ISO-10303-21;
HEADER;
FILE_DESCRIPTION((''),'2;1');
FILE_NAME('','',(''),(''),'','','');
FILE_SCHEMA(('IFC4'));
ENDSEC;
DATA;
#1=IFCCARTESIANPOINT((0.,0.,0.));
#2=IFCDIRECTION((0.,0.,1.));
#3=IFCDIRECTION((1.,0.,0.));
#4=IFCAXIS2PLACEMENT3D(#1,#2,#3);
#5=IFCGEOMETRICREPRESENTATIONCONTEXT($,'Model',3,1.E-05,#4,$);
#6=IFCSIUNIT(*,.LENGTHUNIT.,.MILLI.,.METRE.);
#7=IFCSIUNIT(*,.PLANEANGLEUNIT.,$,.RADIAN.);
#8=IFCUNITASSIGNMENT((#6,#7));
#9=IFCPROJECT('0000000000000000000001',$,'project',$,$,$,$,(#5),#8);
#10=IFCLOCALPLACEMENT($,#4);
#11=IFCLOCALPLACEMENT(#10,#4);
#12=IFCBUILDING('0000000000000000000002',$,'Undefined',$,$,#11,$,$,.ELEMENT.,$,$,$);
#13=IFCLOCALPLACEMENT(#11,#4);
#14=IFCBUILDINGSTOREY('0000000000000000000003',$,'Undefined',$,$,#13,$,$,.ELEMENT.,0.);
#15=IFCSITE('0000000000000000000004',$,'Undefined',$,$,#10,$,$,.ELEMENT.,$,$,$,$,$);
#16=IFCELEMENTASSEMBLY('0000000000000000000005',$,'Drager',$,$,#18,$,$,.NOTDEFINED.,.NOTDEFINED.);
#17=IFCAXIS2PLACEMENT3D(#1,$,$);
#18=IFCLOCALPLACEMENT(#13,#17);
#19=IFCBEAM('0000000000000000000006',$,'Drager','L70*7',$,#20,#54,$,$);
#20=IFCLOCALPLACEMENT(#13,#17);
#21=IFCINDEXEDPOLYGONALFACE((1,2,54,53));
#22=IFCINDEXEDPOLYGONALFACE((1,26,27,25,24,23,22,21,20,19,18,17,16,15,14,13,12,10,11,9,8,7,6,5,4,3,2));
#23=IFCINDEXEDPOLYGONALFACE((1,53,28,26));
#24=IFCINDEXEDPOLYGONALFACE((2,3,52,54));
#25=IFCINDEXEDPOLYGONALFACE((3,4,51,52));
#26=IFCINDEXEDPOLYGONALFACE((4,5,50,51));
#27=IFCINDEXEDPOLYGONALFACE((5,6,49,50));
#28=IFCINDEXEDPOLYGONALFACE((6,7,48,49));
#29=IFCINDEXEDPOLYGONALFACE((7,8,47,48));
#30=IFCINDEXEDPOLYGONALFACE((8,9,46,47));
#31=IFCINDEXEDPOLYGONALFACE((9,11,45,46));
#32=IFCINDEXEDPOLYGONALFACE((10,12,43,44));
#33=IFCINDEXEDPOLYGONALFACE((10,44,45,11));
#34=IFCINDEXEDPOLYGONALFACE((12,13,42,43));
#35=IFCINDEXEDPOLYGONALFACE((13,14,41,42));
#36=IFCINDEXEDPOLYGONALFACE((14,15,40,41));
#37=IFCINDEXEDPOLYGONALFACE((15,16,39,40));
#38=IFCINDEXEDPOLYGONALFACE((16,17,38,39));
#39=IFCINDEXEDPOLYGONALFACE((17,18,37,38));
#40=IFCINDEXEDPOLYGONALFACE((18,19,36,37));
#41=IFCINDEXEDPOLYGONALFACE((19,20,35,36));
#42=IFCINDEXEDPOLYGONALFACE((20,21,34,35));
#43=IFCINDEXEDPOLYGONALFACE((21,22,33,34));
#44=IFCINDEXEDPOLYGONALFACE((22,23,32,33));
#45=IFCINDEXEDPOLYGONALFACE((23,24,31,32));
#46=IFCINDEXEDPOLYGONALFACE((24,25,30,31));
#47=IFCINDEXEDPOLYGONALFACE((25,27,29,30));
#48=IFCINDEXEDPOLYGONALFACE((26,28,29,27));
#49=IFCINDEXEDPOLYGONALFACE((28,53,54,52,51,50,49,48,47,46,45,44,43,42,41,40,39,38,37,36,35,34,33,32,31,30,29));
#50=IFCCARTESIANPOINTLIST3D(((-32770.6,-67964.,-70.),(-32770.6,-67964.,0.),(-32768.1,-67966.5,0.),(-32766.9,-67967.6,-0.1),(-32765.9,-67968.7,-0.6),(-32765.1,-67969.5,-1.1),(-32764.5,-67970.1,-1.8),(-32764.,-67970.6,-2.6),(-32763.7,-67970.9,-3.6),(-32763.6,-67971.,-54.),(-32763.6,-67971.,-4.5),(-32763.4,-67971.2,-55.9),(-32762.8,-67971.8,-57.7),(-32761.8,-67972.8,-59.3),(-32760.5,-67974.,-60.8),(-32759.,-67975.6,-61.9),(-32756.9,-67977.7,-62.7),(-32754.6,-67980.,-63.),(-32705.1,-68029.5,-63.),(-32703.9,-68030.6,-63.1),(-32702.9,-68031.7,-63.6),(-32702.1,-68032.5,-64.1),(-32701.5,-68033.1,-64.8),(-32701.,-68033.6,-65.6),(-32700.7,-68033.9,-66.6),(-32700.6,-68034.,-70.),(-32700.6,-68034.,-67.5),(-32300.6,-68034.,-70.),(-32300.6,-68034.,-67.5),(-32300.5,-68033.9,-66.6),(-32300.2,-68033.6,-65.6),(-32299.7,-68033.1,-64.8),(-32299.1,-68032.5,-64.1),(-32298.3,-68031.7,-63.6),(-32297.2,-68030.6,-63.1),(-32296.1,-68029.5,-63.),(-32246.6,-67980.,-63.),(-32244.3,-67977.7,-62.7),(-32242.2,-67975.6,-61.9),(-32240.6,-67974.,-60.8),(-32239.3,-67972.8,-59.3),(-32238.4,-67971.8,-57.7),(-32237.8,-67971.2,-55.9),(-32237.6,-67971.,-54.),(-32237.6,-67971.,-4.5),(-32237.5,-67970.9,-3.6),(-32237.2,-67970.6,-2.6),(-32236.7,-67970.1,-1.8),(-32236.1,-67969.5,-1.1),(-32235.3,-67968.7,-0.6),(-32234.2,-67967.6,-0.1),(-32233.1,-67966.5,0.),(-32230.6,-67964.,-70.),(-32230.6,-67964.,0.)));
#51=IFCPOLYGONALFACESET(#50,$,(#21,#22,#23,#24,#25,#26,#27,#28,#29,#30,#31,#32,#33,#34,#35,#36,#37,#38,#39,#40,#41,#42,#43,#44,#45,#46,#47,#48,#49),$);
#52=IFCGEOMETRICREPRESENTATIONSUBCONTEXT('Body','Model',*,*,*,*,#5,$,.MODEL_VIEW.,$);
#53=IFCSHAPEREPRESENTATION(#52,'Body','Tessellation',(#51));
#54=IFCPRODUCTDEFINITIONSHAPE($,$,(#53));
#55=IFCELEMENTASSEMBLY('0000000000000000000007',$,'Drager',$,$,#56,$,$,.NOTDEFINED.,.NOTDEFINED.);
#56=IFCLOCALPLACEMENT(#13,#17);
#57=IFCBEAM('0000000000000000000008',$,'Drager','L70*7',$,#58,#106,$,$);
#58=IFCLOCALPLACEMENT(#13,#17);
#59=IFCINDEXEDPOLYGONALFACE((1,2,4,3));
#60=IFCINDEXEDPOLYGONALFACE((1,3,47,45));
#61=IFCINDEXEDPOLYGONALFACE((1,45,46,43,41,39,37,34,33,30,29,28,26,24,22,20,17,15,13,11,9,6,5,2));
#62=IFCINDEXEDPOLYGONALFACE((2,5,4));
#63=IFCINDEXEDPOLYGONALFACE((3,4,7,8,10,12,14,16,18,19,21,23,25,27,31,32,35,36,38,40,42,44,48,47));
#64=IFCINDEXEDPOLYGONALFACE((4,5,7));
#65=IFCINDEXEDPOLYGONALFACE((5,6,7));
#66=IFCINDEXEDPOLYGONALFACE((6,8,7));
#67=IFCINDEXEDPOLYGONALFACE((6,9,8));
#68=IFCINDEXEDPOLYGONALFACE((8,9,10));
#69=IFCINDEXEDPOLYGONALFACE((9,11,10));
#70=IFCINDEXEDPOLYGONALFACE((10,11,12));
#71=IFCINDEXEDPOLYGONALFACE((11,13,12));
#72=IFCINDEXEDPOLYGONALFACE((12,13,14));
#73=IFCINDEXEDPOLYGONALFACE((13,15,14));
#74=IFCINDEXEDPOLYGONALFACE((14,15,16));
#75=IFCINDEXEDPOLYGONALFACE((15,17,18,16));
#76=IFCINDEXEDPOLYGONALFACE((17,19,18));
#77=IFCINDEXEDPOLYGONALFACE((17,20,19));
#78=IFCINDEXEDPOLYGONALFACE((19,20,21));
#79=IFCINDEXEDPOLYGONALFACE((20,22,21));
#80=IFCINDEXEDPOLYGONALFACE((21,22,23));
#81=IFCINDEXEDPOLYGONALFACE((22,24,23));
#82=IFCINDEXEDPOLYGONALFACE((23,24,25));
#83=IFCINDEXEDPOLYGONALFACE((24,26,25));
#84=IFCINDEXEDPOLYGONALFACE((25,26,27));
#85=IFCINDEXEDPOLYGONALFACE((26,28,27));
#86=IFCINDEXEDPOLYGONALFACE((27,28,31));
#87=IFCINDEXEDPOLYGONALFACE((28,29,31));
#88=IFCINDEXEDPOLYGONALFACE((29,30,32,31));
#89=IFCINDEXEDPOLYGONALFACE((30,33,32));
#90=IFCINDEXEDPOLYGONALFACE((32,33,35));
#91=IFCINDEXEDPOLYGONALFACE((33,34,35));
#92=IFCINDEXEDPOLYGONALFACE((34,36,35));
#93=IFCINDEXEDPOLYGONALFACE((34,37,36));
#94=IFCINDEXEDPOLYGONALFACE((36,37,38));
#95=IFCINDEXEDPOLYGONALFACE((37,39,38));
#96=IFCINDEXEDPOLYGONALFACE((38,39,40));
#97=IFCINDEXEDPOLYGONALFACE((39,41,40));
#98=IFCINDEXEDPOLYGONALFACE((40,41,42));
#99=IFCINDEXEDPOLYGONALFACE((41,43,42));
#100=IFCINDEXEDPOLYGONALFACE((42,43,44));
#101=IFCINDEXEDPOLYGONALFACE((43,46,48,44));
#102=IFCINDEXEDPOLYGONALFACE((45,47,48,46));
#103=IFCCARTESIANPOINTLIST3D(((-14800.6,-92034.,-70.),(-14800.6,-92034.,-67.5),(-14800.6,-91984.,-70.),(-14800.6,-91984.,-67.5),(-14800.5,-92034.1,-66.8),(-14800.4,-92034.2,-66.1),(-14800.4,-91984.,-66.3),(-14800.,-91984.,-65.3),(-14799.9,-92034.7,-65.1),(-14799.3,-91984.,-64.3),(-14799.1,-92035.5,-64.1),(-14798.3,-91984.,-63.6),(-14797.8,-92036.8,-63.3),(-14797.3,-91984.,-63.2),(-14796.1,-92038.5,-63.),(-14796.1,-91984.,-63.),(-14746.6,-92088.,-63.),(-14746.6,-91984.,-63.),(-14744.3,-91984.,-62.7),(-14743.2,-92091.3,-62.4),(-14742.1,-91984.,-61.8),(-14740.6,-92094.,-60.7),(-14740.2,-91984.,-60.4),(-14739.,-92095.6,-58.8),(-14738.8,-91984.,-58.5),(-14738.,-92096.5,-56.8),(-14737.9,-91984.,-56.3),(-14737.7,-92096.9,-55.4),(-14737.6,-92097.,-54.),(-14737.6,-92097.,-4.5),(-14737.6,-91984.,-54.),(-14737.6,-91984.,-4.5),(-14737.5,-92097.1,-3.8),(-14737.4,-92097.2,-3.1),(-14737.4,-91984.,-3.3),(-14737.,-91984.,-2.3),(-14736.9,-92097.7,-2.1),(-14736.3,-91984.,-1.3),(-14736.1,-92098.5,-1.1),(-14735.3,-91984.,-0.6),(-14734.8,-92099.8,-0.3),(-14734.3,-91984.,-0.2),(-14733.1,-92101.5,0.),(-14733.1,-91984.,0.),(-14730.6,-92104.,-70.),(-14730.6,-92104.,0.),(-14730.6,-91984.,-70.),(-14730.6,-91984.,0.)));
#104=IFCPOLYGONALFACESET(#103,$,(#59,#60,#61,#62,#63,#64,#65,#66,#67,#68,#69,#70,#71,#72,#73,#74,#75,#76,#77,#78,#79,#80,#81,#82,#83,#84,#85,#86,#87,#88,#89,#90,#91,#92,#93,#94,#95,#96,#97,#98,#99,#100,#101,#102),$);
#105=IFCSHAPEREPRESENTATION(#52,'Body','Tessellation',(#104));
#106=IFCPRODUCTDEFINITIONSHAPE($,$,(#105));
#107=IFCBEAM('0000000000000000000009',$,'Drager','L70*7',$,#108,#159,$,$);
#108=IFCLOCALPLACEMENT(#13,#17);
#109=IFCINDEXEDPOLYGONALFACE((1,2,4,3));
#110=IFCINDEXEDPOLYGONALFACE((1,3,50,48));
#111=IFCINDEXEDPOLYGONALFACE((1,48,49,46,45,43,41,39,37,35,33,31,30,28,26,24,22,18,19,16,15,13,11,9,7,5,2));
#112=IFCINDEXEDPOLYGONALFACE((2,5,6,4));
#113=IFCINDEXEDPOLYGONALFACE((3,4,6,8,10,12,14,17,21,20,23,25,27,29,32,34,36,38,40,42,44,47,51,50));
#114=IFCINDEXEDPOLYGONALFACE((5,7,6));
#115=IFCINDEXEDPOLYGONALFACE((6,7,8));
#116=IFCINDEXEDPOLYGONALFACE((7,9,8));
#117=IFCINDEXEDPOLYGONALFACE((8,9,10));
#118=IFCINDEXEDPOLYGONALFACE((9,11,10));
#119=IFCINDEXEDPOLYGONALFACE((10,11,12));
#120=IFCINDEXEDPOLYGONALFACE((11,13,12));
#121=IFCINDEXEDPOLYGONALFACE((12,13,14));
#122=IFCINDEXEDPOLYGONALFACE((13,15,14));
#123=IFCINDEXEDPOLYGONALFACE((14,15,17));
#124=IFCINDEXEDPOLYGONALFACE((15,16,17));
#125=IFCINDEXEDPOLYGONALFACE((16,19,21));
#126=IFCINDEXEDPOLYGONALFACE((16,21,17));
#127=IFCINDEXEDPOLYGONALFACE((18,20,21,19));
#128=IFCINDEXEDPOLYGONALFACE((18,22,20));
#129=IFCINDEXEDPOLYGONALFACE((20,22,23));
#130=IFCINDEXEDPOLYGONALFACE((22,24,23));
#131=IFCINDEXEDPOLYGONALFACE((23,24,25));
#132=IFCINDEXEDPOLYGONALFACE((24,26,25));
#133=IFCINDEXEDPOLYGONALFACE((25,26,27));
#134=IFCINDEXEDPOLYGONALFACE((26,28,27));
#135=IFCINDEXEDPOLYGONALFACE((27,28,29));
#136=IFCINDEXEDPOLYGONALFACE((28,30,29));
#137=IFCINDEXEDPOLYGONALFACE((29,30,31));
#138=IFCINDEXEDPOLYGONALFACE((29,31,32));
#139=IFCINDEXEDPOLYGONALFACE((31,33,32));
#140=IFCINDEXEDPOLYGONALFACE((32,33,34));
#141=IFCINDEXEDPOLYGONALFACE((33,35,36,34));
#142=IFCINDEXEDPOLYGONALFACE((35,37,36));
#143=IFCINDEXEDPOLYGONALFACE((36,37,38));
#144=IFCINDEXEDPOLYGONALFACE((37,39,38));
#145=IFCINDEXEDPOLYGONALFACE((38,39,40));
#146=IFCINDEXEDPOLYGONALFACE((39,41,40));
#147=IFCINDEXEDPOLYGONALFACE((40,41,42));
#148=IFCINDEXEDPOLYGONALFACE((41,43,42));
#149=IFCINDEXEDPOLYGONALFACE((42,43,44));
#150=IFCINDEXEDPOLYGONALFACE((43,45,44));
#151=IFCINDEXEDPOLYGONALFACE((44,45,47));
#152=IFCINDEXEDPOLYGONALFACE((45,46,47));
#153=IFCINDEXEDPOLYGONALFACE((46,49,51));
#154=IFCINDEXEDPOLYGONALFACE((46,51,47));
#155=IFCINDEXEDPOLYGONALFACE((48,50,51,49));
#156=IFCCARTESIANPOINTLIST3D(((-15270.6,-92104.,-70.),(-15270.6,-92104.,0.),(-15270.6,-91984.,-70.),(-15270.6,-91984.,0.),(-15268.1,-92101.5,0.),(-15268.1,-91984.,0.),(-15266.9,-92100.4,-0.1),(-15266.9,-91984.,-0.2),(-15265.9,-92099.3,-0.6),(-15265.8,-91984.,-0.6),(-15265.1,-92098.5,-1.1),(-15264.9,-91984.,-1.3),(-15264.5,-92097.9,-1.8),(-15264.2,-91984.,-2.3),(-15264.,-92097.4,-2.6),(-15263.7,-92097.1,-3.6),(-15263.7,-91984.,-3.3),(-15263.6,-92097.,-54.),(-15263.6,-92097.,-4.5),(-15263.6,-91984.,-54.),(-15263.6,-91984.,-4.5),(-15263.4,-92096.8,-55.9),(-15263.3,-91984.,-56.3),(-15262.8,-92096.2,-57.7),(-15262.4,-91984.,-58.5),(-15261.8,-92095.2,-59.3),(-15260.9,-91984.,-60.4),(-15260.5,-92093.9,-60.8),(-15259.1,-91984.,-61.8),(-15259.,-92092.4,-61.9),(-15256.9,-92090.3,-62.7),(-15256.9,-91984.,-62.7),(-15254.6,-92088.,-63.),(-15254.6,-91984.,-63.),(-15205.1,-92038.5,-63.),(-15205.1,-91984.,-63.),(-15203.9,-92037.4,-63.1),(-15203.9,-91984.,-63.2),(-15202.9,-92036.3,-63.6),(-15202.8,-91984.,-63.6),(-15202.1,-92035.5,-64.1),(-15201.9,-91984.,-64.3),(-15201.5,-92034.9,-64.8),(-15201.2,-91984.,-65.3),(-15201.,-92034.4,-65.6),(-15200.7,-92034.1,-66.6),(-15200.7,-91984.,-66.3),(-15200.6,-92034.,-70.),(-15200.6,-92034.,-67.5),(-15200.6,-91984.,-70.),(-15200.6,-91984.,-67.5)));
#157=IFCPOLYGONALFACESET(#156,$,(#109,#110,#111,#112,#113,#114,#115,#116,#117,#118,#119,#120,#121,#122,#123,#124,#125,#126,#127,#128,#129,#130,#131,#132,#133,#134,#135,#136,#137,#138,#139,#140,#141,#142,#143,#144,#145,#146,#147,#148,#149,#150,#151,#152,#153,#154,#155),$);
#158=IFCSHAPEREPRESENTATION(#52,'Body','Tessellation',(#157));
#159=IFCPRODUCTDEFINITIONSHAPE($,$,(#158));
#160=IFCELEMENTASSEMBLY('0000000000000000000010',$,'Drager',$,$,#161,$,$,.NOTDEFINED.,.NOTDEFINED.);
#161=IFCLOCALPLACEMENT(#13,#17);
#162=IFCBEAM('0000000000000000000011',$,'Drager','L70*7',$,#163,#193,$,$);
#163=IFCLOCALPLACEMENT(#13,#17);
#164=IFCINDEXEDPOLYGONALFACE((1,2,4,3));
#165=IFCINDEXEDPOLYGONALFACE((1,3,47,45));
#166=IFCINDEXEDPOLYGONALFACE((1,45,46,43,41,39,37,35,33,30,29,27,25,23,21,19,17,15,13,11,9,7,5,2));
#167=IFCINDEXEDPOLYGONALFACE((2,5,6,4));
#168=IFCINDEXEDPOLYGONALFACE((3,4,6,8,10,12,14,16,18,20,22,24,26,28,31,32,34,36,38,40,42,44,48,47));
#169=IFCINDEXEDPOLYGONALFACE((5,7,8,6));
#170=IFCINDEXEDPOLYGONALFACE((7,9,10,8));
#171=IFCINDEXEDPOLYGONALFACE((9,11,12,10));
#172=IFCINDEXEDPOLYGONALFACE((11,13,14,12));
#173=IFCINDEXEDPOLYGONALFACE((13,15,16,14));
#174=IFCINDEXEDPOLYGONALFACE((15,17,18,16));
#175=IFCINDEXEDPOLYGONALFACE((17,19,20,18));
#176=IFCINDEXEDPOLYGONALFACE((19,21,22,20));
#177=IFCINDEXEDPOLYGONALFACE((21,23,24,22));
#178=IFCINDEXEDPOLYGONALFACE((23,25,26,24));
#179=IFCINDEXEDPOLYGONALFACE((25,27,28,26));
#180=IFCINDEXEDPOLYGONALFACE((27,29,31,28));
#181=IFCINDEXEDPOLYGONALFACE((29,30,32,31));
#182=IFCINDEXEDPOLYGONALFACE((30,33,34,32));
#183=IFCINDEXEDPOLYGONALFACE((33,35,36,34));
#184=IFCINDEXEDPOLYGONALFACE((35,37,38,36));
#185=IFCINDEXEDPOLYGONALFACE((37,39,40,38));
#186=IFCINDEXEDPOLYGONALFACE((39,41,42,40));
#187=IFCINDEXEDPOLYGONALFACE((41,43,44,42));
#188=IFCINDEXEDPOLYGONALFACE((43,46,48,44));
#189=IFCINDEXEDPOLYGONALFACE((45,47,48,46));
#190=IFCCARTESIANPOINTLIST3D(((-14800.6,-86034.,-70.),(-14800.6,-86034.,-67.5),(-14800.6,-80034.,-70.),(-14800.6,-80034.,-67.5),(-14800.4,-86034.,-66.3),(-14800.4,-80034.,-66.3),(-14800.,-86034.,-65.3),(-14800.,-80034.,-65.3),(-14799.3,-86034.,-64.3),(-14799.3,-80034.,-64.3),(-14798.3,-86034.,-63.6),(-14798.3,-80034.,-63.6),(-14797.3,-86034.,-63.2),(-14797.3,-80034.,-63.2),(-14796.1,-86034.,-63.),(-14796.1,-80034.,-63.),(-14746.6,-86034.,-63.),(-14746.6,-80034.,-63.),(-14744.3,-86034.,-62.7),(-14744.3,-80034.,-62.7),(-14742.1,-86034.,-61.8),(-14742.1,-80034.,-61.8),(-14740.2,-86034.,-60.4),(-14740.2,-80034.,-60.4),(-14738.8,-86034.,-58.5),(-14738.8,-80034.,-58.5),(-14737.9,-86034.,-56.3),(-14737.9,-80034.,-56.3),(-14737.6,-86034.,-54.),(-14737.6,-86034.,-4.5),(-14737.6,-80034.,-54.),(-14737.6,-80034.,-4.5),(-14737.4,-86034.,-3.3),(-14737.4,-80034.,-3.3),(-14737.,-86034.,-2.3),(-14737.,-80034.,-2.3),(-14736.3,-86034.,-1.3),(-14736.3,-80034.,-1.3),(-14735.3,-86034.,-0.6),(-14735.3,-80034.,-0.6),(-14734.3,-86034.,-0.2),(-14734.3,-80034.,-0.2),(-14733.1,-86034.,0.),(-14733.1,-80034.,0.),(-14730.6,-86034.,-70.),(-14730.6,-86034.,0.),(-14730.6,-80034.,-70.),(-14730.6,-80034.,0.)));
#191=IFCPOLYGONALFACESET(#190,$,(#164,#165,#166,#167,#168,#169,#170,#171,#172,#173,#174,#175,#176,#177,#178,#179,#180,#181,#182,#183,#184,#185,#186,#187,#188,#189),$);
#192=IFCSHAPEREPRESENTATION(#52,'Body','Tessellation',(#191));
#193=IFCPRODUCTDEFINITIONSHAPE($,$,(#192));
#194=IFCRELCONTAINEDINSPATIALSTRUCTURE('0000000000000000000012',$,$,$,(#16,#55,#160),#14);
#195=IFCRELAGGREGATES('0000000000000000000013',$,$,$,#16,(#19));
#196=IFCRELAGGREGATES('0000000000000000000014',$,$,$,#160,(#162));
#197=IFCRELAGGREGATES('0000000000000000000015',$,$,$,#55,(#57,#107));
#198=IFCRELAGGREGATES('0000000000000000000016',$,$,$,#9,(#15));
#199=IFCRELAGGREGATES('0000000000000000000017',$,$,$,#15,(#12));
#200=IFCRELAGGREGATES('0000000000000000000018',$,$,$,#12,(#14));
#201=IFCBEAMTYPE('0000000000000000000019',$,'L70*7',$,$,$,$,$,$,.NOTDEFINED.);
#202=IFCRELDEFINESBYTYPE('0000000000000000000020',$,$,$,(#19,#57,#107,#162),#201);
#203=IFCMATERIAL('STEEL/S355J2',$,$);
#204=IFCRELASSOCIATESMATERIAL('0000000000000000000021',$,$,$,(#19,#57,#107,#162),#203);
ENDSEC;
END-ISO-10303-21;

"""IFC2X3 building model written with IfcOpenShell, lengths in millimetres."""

from ifc_helpers import new_model, si_unit, frame, origin_with_axes, origin_2d_with_axis, place, context, subcontext, project, spatial, l_section, extrude, clip, halfspace, material, type_object, element, aggregate, save


model = new_model("IFC2X3")

# Units and contexts
model_context = context("Model", 3, precision=1e-05, world=origin_with_axes())
body_context = subcontext(model_context, "Body", "Model", "MODEL_VIEW")
ifc_project = project(units=[si_unit("LENGTHUNIT", "METRE", prefix="MILLI"), si_unit("PLANEANGLEUNIT", "RADIAN")], contexts=[model_context])

# Site, building, storey
site_placement = place(None, origin_with_axes())
site = spatial("IfcSite", under=ifc_project, at=site_placement, Name="Undefined", CompositionType="ELEMENT")
building_placement = place(site_placement, origin_with_axes())
building = spatial("IfcBuilding", under=site, at=building_placement, Name="Undefined", CompositionType="ELEMENT")
storey_placement = place(building_placement, origin_with_axes())
storey = spatial("IfcBuildingStorey", under=building, at=storey_placement, Name="Undefined", CompositionType="ELEMENT", Elevation=0.0)

# Shared definitions
ifc_material = material(Name="STEEL/S355J2")
beam_type = type_object("IfcBeamType", Name="L70*7", PredefinedType="NOTDEFINED")

# Element assembly
assembly_1_placement = place(storey_placement, origin_with_axes())
assembly_1 = element("IfcElementAssembly", 1, at=assembly_1_placement, inside=storey, Name="Drager", AssemblyPlace="NOTDEFINED", PredefinedType="NOTDEFINED")

# Beam
beam_1_placement = place(assembly_1_placement, frame((-32700.6, -67999.0, -35.0), z_axis=(0.0, 0.0, 1.0), x_axis=(1.0, 0.0, 0.0)))
beam_1 = element("IfcBeam", 2, at=beam_1_placement, type_object=beam_type, material=ifc_material, Name="Drager", Description="L70*7", context=body_context, shape_type="Clipping", body=[
    clip(clip(extrude(l_section(Depth=70.0, Width=70.0, Thickness=7.0, FilletRadius=9.0, EdgeRadius=4.5, at=origin_2d_with_axis()), frame((505.7, 0.0, 0.0), z_axis=(-1.0, 0.0, 0.0), x_axis=(0.0, -1.0, 0.0)), (0.0, 0.0, 1.0), 611.4), halfspace(frame((400.0, -35.0, 35.0), z_axis=(-0.707107, 0.707107, 0.0), x_axis=(0.707107, 0.707107, 0.0)), True)), halfspace(frame((0.0, -35.0, 35.0), z_axis=(-0.707107, -0.707107, 0.0), x_axis=(-0.707107, 0.707107, 0.0)), False)),
])
aggregate(assembly_1, [beam_1])

# Element assembly, beams
assembly_2_placement = place(storey_placement, origin_with_axes())
assembly_2 = element("IfcElementAssembly", 3, at=assembly_2_placement, inside=storey, Name="Drager", AssemblyPlace="NOTDEFINED", PredefinedType="NOTDEFINED")
beam_2_placement = place(assembly_2_placement, frame((-14765.6, -91984.0, -35.0), z_axis=(0.0, 0.0, 1.0), x_axis=(0.0, -1.0, 0.0)))
beam_2 = element("IfcBeam", 4, at=beam_2_placement, type_object=beam_type, material=ifc_material, Name="Drager", Description="L70*7", context=body_context, shape_type="Clipping", body=[
    clip(extrude(l_section(Depth=70.0, Width=70.0, Thickness=7.0, FilletRadius=9.0, EdgeRadius=4.5, at=origin_2d_with_axis()), frame((120.3, 0.0, 0.0), z_axis=(-1.0, 0.0, 0.0), x_axis=(0.0, -1.0, 0.0)), (0.0, 0.0, 1.0), 120.3), halfspace(frame((50.0, -35.0, 35.0), z_axis=(0.707107, -0.707107, 0.0), x_axis=(0.0, 0.0, 1.0)), False)),
])
beam_3_placement = place(assembly_2_placement, frame((-15235.6, -92034.0, -35.0), z_axis=(0.0, 0.0, 1.0), x_axis=(0.0, 1.0, 0.0)))
beam_3 = element("IfcBeam", 5, at=beam_3_placement, type_object=beam_type, material=ifc_material, Name="Drager", Description="L70*7", context=body_context, shape_type="Clipping", body=[
    clip(extrude(l_section(Depth=70.0, Width=70.0, Thickness=7.0, FilletRadius=9.0, EdgeRadius=4.5, at=origin_2d_with_axis()), frame((50.0, 0.0, 0.0), z_axis=(-1.0, 0.0, 0.0), x_axis=(0.0, -1.0, 0.0)), (0.0, 0.0, 1.0), 120.3), halfspace(frame((0.0, -35.0, 35.0), z_axis=(-0.707107, -0.707107, 0.0), x_axis=(-0.707107, 0.707107, 0.0)), False)),
])

# Element assembly, beam
assembly_3_placement = place(storey_placement, origin_with_axes())
assembly_3 = element("IfcElementAssembly", 6, at=assembly_3_placement, inside=storey, Name="Drager", AssemblyPlace="NOTDEFINED", PredefinedType="NOTDEFINED")
beam_4_placement = place(assembly_3_placement, frame((-14765.6, -80034.0, -35.0), z_axis=(0.0, 0.0, 1.0), x_axis=(0.0, -1.0, 0.0)))
beam_4 = element("IfcBeam", 7, at=beam_4_placement, type_object=beam_type, material=ifc_material, Name="Drager", Description="L70*7", context=body_context, shape_type="SweptSolid", body=[
    extrude(l_section(Depth=70.0, Width=70.0, Thickness=7.0, FilletRadius=9.0, EdgeRadius=4.5, at=origin_2d_with_axis()), frame((6000.0, 0.0, 0.0), z_axis=(-1.0, 0.0, 0.0), x_axis=(0.0, -1.0, 0.0)), (0.0, 0.0, 1.0), 6000.0),
])
aggregate(assembly_3, [beam_4])

aggregate(assembly_2, [beam_2, beam_3])

save(model, "model.ifc")
